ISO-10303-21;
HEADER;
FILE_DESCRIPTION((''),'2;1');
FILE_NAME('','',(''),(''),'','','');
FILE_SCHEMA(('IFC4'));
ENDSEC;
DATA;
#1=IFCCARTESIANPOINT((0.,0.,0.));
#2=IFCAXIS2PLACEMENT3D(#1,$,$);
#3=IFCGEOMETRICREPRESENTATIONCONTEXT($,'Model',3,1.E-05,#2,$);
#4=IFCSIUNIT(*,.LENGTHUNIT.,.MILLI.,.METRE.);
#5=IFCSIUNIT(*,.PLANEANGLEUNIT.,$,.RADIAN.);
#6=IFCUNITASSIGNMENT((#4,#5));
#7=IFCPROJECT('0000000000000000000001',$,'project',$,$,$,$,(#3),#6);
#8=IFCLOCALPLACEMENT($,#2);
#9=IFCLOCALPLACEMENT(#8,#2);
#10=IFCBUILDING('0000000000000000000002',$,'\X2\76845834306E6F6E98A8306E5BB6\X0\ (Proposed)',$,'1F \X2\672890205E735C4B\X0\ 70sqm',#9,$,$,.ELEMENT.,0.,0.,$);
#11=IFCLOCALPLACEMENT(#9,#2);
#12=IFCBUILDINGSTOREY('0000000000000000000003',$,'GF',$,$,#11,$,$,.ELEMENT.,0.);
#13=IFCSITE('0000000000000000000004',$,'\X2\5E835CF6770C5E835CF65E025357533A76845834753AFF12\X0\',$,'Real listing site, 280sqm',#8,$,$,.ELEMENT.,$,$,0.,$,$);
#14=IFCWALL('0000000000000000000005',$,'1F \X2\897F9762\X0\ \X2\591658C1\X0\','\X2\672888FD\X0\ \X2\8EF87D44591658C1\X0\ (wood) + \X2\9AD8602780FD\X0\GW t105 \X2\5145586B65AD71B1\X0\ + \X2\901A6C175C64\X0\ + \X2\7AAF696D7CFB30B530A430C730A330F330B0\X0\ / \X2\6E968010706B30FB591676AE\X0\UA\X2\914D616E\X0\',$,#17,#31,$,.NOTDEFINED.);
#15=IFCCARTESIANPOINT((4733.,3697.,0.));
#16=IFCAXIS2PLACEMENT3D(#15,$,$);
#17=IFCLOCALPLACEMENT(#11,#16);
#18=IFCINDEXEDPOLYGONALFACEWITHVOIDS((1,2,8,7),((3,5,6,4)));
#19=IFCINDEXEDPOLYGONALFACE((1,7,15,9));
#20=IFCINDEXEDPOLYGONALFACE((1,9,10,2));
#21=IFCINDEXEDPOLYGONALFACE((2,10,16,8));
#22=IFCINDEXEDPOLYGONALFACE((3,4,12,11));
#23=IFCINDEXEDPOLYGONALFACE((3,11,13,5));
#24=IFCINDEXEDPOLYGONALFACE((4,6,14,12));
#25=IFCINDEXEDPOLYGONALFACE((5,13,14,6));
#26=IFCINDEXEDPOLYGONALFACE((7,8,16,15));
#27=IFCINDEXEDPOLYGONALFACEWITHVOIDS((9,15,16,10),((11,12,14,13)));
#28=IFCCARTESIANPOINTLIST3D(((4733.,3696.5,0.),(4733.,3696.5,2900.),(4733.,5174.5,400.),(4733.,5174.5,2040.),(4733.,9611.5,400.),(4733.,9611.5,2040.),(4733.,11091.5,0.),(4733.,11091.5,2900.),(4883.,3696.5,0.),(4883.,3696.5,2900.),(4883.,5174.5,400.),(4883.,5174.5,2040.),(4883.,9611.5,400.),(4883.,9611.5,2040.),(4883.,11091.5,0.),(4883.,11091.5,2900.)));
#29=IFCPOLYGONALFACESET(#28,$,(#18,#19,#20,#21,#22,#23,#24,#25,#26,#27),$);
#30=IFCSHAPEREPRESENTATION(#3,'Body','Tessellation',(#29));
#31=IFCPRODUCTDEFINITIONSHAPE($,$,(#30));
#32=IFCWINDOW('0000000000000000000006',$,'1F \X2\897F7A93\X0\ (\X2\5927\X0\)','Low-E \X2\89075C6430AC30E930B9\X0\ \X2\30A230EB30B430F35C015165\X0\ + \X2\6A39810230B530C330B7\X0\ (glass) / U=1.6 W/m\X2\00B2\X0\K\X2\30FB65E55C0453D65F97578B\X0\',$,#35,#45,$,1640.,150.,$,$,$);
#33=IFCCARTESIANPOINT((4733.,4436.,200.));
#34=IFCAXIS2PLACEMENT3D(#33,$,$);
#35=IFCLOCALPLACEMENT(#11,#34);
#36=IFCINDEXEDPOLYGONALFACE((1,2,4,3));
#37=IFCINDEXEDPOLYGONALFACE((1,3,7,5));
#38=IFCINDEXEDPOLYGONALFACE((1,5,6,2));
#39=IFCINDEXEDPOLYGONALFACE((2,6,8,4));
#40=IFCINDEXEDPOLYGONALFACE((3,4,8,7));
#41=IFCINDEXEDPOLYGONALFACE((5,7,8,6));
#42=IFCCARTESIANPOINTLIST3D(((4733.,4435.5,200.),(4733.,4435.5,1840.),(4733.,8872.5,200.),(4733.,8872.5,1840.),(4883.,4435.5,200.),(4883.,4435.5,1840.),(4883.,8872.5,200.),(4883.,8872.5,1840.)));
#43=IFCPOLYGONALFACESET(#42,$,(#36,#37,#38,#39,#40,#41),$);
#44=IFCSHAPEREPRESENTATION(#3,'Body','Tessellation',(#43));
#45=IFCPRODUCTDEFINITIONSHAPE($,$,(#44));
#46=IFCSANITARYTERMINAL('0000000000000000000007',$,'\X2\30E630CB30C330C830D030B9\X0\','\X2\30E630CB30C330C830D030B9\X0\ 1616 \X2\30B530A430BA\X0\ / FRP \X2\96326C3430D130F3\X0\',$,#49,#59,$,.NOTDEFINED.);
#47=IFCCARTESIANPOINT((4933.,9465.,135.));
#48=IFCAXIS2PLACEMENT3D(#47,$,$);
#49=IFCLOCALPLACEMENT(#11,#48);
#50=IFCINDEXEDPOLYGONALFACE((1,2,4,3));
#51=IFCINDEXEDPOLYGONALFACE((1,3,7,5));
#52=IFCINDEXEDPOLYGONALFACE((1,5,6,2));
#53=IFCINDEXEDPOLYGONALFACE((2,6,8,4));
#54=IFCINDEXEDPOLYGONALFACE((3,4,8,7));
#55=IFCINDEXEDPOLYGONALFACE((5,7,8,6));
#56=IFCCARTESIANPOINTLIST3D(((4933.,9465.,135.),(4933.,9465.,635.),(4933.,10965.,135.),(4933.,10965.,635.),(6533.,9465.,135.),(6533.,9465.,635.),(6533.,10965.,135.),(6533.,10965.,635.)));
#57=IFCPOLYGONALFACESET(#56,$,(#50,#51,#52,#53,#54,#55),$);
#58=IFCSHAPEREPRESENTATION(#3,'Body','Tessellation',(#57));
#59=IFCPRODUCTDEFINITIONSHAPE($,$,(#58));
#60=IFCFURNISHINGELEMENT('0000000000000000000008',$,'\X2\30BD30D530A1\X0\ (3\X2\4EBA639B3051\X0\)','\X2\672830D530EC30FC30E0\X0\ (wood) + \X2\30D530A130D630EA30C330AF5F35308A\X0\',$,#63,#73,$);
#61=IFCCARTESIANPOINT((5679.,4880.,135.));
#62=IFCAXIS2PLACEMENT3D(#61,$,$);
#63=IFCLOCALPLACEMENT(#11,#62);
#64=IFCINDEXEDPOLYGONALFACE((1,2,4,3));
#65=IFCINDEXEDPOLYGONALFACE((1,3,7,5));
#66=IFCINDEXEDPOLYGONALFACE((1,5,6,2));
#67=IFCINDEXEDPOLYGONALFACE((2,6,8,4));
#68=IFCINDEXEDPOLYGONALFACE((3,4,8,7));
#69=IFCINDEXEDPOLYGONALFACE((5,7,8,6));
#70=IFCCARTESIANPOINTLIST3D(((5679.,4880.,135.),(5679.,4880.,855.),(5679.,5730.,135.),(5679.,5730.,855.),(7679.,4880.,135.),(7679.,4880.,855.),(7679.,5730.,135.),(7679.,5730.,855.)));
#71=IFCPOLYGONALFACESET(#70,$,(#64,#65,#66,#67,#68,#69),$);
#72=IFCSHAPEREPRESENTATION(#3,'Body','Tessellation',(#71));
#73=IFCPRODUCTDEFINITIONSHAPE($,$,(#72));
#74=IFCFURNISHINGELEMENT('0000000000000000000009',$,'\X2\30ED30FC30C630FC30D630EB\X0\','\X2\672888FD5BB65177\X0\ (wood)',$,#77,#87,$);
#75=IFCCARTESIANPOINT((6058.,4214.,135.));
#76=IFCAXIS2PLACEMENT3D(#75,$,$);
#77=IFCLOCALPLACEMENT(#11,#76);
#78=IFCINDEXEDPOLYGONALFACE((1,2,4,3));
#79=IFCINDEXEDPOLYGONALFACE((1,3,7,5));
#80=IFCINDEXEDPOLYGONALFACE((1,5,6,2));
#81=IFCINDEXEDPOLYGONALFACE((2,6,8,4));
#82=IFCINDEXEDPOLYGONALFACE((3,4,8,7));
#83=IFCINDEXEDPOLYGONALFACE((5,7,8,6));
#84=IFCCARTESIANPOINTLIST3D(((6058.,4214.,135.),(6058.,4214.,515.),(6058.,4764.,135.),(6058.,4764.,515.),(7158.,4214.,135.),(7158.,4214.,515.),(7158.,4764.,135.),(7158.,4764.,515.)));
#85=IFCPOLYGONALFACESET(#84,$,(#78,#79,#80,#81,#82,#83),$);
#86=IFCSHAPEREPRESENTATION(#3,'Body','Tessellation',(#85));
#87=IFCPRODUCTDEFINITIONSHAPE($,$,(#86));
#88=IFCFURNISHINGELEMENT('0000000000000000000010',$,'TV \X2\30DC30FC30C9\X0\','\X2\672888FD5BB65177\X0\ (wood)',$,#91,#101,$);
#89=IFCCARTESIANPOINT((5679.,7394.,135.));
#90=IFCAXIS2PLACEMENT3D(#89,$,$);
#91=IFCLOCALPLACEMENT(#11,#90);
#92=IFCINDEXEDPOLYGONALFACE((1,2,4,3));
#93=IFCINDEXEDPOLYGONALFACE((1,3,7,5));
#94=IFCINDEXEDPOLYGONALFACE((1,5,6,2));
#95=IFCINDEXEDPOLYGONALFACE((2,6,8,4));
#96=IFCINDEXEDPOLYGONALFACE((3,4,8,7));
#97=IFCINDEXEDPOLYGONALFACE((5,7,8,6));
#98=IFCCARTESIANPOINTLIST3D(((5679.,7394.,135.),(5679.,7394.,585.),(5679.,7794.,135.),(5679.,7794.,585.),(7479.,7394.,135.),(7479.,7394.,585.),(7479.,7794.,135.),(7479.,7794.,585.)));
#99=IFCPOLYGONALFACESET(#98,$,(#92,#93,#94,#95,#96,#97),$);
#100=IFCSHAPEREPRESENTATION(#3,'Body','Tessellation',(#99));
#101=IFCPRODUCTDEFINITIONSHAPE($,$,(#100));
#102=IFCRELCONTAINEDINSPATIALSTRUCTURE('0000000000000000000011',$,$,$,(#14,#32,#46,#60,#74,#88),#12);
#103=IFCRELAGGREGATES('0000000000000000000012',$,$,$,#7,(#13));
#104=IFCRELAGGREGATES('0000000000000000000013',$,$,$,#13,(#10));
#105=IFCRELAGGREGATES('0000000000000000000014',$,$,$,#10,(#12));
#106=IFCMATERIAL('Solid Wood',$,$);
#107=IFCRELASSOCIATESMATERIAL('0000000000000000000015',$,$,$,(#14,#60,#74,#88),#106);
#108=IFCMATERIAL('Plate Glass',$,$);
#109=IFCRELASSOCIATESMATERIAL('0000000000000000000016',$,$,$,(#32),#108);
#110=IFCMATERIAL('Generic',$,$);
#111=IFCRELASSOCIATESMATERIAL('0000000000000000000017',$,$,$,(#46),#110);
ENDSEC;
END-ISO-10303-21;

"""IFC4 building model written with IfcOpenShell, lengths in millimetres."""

from ifc_helpers import new_model, si_unit, frame, frame_2d, origin, place, context, project, spatial, rectangle, extrude, material, element, fill, save


model = new_model("IFC4")

# Units and contexts
model_context = context("Model", 3, precision=1e-05, world=origin())
ifc_project = project(units=[si_unit("LENGTHUNIT", "METRE", prefix="MILLI"), si_unit("PLANEANGLEUNIT", "RADIAN")], contexts=[model_context])

# Site, building, storey
site_placement = place(None, origin())
site = spatial("IfcSite", under=ifc_project, at=site_placement, Name="広島県広島市南区的場町２", ObjectType="Real listing site, 280sqm", CompositionType="ELEMENT", RefElevation=0.0)
building_placement = place(site_placement, origin())
building = spatial("IfcBuilding", under=site, at=building_placement, Name="的場の潮風の家 (Proposed)", ObjectType="1F 木造平屋 70sqm", CompositionType="ELEMENT", ElevationOfRefHeight=0.0, ElevationOfTerrain=0.0)
storey_placement = place(building_placement, origin())
storey = spatial("IfcBuildingStorey", under=building, at=storey_placement, Name="GF", CompositionType="ELEMENT", Elevation=0.0)

# Shared definitions
ifc_material_1 = material(Name="Solid Wood")

# Shared definitions
ifc_material_2 = material(Name="Plate Glass")

# Wall, opening, window
wall_1_placement = place(storey_placement, frame((4733.0, 3697.0, 0.0)))
wall_1 = element("IfcWall", 1, at=wall_1_placement, inside=storey, material=ifc_material_1, Name="1F 西面 外壁", Description="木製 軸組外壁 (wood) + 高性能GW t105 充填断熱 + 通気層 + 窯業系サイディング / 準耐火・外皮UA配慮", PredefinedType="NOTDEFINED", context=model_context, shape_type="SweptSolid", body=[
    extrude(rectangle(XDim=150.0, YDim=7395.0, at=frame_2d((75.0, 3697.0))), frame((4733.0, 3697.0, 0.0)), (0.0, 0.0, 1.0), 2900.0),
])
opening_1_placement = place(storey_placement, frame((4733.0, 4436.0, 200.0)))
opening_1 = element("IfcOpeningElement", 2, at=opening_1_placement, cuts=wall_1, PredefinedType="NOTDEFINED", context=model_context, shape_type="SweptSolid", body=[
    extrude(rectangle(XDim=150.0, YDim=4437.0, at=frame_2d((75.0, 2218.0))), frame((4733.0, 4436.0, 200.0)), (0.0, 0.0, 1.0), 1640.0),
])
window_1_placement = place(storey_placement, frame((4733.0, 4436.0, 200.0)))
window_1 = element("IfcWindow", 3, at=window_1_placement, inside=storey, material=ifc_material_2, Name="1F 西窓 (大)", Description="Low-E 複層ガラス アルゴン封入 + 樹脂サッシ (glass) / U=1.6 W/m²K・日射取得型", OverallHeight=1640.0, OverallWidth=150.0, context=model_context, shape_type="SweptSolid", body=[
    extrude(rectangle(XDim=150.0, YDim=4437.0, at=frame_2d((75.0, 2218.0))), frame((4733.0, 4436.0, 200.0)), (0.0, 0.0, 1.0), 1640.0),
])
fill(opening_1, window_1)

# Shared definitions
ifc_material_3 = material(Name="Generic")

# Sanitary terminal
sanitary_terminal_placement = place(storey_placement, frame((4933.0, 9465.0, 135.0)))
element("IfcSanitaryTerminal", 4, at=sanitary_terminal_placement, inside=storey, material=ifc_material_3, Name="ユニットバス", Description="ユニットバス 1616 サイズ / FRP 防水パン", PredefinedType="NOTDEFINED", context=model_context, shape_type="SweptSolid", body=[
    extrude(rectangle(XDim=1600.0, YDim=1500.0, at=frame_2d((800.0, 750.0))), frame((4933.0, 9465.0, 135.0)), (0.0, 0.0, 1.0), 500.0),
])

# Furnishing elements
furnishing_1_placement = place(storey_placement, frame((5679.0, 4880.0, 135.0)))
element("IfcFurnishingElement", 5, at=furnishing_1_placement, inside=storey, material=ifc_material_1, Name="ソファ (3人掛け)", Description="木フレーム (wood) + ファブリック張り", context=model_context, shape_type="SweptSolid", body=[
    extrude(rectangle(XDim=2000.0, YDim=850.0, at=frame_2d((1000.0, 425.0))), frame((5679.0, 4880.0, 135.0)), (0.0, 0.0, 1.0), 720.0),
])
furnishing_2_placement = place(storey_placement, frame((6058.0, 4214.0, 135.0)))
element("IfcFurnishingElement", 6, at=furnishing_2_placement, inside=storey, material=ifc_material_1, Name="ローテーブル", Description="木製家具 (wood)", context=model_context, shape_type="SweptSolid", body=[
    extrude(rectangle(XDim=1100.0, YDim=550.0, at=frame_2d((550.0, 275.0))), frame((6058.0, 4214.0, 135.0)), (0.0, 0.0, 1.0), 380.0),
])
furnishing_3_placement = place(storey_placement, frame((5679.0, 7394.0, 135.0)))
element("IfcFurnishingElement", 7, at=furnishing_3_placement, inside=storey, material=ifc_material_1, Name="TV ボード", Description="木製家具 (wood)", context=model_context, shape_type="SweptSolid", body=[
    extrude(rectangle(XDim=1800.0, YDim=400.0, at=frame_2d((900.0, 200.0))), frame((5679.0, 7394.0, 135.0)), (0.0, 0.0, 1.0), 450.0),
])

save(model, "model.ifc")
